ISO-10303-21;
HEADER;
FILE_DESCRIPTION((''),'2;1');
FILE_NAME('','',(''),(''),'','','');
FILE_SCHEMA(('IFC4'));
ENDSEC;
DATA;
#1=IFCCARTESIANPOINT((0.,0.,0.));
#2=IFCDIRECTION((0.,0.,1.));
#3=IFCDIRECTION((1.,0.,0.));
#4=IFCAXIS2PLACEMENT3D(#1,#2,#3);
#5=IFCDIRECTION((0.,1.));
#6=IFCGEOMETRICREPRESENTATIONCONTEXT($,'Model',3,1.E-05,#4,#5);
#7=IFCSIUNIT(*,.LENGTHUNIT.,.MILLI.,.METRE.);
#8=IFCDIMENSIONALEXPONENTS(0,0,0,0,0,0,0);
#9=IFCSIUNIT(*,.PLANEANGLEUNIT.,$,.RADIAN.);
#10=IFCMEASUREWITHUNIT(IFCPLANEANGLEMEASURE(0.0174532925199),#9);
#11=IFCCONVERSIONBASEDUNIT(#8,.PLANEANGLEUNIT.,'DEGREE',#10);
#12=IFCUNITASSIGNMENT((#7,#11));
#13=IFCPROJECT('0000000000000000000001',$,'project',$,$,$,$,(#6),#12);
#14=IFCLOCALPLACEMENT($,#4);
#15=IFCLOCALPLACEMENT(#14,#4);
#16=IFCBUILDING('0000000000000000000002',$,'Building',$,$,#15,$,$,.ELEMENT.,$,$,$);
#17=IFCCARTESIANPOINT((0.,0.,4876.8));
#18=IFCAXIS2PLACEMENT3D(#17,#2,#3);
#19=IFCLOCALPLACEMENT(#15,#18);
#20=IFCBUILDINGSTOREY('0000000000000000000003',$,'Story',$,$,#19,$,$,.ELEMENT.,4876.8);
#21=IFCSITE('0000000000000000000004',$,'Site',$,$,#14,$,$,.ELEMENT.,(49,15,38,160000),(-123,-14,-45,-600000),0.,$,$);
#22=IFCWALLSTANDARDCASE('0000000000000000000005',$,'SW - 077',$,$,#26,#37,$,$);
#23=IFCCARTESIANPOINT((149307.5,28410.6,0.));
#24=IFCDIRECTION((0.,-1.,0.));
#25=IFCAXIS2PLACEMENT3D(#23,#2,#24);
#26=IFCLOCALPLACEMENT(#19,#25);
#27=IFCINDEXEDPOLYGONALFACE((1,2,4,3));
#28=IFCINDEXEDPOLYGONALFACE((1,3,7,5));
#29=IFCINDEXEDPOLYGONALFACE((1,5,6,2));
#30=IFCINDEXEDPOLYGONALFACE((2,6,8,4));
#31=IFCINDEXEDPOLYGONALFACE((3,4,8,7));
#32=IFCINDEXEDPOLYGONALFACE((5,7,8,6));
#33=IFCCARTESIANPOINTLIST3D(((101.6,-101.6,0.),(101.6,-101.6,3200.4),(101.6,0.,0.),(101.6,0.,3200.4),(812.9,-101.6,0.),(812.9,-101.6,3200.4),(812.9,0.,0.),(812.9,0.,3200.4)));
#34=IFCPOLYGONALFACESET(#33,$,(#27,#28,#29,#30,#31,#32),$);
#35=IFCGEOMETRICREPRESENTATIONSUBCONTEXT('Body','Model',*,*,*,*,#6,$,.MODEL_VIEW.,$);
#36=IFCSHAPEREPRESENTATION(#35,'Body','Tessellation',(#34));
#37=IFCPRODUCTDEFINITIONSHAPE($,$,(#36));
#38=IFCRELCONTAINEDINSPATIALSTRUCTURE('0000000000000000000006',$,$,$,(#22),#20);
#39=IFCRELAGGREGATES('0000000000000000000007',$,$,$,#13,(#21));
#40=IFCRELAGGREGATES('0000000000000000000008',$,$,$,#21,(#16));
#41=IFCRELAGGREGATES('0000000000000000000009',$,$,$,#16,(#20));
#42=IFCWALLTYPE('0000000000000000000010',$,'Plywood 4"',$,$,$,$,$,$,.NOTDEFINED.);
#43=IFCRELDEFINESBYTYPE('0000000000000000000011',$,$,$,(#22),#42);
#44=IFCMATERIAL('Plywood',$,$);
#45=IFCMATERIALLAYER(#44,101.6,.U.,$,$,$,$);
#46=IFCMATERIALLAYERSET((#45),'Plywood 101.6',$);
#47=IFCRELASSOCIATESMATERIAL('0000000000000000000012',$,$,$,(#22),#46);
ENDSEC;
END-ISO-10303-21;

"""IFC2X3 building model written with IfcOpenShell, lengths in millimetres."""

from ifc_helpers import new_model, entity, si_unit, converted_unit, direction, frame, origin_with_axes, place, context, subcontext, project, spatial, polyline, outline, extrude, material, layer, layer_set, layer_usage, type_object, element, save


model = new_model("IFC2X3")

# Units and contexts
model_context = context("Model", 3, precision=1e-05, world=origin_with_axes(), true_north=direction((0.0, 1.0)))
body_context = subcontext(model_context, "Body", "Model", "MODEL_VIEW")
ifc_project = project(units=[si_unit("LENGTHUNIT", "METRE", prefix="MILLI"), converted_unit("PLANEANGLEUNIT", "DEGREE", entity("IfcPlaneAngleMeasure", 0.0174532925199), si_unit("PLANEANGLEUNIT", "RADIAN"), dimensions=[0, 0, 0, 0, 0, 0, 0])], contexts=[model_context])

# Site, building, storey
site_placement = place(None, origin_with_axes())
site = spatial("IfcSite", under=ifc_project, at=site_placement, Name="Site", CompositionType="ELEMENT", RefLatitude=(49, 15, 38, 160000), RefLongitude=(-123, -14, -45, -600000), RefElevation=0.0)
building_placement = place(site_placement, origin_with_axes())
building = spatial("IfcBuilding", under=site, at=building_placement, Name="Building", CompositionType="ELEMENT")
storey_placement = place(building_placement, frame((0.0, 0.0, 4876.8), z_axis=(0.0, 0.0, 1.0), x_axis=(1.0, 0.0, 0.0)))
storey = spatial("IfcBuildingStorey", under=building, at=storey_placement, Name="Story", CompositionType="ELEMENT", Elevation=4876.8)

# Shared definitions
ifc_material_1 = material(Name="Plywood")

# Wall
ifc_layer_1 = layer(ifc_material_1, 101.6, ventilated="UNKNOWN")
ifc_layer_set_1 = layer_set([ifc_layer_1], Name="Plywood 101.6")
wall_type_1 = type_object("IfcWallType", Name="Plywood 4\"", PredefinedType="NOTDEFINED")
ifc_layer_usage_1 = layer_usage(ifc_layer_set_1, "AXIS2", "NEGATIVE", 0.0)
wall_1_placement = place(storey_placement, frame((149307.5, 28410.6, 0.0), z_axis=(0.0, 0.0, 1.0), x_axis=(0.0, -1.0, 0.0)))
element("IfcWallStandardCase", 1, at=wall_1_placement, inside=storey, type_object=wall_type_1, material=ifc_layer_usage_1, Name="SW - 077", context=body_context, shape_type="SweptSolid", body=[
    extrude(outline(polyline([(101.6, -101.6), (812.9, -101.6), (812.9, 0.0), (101.6, 0.0), (101.6, -101.6)])), origin_with_axes(), (0.0, 0.0, 1.0), 3200.4),
])

save(model, "model.ifc")
